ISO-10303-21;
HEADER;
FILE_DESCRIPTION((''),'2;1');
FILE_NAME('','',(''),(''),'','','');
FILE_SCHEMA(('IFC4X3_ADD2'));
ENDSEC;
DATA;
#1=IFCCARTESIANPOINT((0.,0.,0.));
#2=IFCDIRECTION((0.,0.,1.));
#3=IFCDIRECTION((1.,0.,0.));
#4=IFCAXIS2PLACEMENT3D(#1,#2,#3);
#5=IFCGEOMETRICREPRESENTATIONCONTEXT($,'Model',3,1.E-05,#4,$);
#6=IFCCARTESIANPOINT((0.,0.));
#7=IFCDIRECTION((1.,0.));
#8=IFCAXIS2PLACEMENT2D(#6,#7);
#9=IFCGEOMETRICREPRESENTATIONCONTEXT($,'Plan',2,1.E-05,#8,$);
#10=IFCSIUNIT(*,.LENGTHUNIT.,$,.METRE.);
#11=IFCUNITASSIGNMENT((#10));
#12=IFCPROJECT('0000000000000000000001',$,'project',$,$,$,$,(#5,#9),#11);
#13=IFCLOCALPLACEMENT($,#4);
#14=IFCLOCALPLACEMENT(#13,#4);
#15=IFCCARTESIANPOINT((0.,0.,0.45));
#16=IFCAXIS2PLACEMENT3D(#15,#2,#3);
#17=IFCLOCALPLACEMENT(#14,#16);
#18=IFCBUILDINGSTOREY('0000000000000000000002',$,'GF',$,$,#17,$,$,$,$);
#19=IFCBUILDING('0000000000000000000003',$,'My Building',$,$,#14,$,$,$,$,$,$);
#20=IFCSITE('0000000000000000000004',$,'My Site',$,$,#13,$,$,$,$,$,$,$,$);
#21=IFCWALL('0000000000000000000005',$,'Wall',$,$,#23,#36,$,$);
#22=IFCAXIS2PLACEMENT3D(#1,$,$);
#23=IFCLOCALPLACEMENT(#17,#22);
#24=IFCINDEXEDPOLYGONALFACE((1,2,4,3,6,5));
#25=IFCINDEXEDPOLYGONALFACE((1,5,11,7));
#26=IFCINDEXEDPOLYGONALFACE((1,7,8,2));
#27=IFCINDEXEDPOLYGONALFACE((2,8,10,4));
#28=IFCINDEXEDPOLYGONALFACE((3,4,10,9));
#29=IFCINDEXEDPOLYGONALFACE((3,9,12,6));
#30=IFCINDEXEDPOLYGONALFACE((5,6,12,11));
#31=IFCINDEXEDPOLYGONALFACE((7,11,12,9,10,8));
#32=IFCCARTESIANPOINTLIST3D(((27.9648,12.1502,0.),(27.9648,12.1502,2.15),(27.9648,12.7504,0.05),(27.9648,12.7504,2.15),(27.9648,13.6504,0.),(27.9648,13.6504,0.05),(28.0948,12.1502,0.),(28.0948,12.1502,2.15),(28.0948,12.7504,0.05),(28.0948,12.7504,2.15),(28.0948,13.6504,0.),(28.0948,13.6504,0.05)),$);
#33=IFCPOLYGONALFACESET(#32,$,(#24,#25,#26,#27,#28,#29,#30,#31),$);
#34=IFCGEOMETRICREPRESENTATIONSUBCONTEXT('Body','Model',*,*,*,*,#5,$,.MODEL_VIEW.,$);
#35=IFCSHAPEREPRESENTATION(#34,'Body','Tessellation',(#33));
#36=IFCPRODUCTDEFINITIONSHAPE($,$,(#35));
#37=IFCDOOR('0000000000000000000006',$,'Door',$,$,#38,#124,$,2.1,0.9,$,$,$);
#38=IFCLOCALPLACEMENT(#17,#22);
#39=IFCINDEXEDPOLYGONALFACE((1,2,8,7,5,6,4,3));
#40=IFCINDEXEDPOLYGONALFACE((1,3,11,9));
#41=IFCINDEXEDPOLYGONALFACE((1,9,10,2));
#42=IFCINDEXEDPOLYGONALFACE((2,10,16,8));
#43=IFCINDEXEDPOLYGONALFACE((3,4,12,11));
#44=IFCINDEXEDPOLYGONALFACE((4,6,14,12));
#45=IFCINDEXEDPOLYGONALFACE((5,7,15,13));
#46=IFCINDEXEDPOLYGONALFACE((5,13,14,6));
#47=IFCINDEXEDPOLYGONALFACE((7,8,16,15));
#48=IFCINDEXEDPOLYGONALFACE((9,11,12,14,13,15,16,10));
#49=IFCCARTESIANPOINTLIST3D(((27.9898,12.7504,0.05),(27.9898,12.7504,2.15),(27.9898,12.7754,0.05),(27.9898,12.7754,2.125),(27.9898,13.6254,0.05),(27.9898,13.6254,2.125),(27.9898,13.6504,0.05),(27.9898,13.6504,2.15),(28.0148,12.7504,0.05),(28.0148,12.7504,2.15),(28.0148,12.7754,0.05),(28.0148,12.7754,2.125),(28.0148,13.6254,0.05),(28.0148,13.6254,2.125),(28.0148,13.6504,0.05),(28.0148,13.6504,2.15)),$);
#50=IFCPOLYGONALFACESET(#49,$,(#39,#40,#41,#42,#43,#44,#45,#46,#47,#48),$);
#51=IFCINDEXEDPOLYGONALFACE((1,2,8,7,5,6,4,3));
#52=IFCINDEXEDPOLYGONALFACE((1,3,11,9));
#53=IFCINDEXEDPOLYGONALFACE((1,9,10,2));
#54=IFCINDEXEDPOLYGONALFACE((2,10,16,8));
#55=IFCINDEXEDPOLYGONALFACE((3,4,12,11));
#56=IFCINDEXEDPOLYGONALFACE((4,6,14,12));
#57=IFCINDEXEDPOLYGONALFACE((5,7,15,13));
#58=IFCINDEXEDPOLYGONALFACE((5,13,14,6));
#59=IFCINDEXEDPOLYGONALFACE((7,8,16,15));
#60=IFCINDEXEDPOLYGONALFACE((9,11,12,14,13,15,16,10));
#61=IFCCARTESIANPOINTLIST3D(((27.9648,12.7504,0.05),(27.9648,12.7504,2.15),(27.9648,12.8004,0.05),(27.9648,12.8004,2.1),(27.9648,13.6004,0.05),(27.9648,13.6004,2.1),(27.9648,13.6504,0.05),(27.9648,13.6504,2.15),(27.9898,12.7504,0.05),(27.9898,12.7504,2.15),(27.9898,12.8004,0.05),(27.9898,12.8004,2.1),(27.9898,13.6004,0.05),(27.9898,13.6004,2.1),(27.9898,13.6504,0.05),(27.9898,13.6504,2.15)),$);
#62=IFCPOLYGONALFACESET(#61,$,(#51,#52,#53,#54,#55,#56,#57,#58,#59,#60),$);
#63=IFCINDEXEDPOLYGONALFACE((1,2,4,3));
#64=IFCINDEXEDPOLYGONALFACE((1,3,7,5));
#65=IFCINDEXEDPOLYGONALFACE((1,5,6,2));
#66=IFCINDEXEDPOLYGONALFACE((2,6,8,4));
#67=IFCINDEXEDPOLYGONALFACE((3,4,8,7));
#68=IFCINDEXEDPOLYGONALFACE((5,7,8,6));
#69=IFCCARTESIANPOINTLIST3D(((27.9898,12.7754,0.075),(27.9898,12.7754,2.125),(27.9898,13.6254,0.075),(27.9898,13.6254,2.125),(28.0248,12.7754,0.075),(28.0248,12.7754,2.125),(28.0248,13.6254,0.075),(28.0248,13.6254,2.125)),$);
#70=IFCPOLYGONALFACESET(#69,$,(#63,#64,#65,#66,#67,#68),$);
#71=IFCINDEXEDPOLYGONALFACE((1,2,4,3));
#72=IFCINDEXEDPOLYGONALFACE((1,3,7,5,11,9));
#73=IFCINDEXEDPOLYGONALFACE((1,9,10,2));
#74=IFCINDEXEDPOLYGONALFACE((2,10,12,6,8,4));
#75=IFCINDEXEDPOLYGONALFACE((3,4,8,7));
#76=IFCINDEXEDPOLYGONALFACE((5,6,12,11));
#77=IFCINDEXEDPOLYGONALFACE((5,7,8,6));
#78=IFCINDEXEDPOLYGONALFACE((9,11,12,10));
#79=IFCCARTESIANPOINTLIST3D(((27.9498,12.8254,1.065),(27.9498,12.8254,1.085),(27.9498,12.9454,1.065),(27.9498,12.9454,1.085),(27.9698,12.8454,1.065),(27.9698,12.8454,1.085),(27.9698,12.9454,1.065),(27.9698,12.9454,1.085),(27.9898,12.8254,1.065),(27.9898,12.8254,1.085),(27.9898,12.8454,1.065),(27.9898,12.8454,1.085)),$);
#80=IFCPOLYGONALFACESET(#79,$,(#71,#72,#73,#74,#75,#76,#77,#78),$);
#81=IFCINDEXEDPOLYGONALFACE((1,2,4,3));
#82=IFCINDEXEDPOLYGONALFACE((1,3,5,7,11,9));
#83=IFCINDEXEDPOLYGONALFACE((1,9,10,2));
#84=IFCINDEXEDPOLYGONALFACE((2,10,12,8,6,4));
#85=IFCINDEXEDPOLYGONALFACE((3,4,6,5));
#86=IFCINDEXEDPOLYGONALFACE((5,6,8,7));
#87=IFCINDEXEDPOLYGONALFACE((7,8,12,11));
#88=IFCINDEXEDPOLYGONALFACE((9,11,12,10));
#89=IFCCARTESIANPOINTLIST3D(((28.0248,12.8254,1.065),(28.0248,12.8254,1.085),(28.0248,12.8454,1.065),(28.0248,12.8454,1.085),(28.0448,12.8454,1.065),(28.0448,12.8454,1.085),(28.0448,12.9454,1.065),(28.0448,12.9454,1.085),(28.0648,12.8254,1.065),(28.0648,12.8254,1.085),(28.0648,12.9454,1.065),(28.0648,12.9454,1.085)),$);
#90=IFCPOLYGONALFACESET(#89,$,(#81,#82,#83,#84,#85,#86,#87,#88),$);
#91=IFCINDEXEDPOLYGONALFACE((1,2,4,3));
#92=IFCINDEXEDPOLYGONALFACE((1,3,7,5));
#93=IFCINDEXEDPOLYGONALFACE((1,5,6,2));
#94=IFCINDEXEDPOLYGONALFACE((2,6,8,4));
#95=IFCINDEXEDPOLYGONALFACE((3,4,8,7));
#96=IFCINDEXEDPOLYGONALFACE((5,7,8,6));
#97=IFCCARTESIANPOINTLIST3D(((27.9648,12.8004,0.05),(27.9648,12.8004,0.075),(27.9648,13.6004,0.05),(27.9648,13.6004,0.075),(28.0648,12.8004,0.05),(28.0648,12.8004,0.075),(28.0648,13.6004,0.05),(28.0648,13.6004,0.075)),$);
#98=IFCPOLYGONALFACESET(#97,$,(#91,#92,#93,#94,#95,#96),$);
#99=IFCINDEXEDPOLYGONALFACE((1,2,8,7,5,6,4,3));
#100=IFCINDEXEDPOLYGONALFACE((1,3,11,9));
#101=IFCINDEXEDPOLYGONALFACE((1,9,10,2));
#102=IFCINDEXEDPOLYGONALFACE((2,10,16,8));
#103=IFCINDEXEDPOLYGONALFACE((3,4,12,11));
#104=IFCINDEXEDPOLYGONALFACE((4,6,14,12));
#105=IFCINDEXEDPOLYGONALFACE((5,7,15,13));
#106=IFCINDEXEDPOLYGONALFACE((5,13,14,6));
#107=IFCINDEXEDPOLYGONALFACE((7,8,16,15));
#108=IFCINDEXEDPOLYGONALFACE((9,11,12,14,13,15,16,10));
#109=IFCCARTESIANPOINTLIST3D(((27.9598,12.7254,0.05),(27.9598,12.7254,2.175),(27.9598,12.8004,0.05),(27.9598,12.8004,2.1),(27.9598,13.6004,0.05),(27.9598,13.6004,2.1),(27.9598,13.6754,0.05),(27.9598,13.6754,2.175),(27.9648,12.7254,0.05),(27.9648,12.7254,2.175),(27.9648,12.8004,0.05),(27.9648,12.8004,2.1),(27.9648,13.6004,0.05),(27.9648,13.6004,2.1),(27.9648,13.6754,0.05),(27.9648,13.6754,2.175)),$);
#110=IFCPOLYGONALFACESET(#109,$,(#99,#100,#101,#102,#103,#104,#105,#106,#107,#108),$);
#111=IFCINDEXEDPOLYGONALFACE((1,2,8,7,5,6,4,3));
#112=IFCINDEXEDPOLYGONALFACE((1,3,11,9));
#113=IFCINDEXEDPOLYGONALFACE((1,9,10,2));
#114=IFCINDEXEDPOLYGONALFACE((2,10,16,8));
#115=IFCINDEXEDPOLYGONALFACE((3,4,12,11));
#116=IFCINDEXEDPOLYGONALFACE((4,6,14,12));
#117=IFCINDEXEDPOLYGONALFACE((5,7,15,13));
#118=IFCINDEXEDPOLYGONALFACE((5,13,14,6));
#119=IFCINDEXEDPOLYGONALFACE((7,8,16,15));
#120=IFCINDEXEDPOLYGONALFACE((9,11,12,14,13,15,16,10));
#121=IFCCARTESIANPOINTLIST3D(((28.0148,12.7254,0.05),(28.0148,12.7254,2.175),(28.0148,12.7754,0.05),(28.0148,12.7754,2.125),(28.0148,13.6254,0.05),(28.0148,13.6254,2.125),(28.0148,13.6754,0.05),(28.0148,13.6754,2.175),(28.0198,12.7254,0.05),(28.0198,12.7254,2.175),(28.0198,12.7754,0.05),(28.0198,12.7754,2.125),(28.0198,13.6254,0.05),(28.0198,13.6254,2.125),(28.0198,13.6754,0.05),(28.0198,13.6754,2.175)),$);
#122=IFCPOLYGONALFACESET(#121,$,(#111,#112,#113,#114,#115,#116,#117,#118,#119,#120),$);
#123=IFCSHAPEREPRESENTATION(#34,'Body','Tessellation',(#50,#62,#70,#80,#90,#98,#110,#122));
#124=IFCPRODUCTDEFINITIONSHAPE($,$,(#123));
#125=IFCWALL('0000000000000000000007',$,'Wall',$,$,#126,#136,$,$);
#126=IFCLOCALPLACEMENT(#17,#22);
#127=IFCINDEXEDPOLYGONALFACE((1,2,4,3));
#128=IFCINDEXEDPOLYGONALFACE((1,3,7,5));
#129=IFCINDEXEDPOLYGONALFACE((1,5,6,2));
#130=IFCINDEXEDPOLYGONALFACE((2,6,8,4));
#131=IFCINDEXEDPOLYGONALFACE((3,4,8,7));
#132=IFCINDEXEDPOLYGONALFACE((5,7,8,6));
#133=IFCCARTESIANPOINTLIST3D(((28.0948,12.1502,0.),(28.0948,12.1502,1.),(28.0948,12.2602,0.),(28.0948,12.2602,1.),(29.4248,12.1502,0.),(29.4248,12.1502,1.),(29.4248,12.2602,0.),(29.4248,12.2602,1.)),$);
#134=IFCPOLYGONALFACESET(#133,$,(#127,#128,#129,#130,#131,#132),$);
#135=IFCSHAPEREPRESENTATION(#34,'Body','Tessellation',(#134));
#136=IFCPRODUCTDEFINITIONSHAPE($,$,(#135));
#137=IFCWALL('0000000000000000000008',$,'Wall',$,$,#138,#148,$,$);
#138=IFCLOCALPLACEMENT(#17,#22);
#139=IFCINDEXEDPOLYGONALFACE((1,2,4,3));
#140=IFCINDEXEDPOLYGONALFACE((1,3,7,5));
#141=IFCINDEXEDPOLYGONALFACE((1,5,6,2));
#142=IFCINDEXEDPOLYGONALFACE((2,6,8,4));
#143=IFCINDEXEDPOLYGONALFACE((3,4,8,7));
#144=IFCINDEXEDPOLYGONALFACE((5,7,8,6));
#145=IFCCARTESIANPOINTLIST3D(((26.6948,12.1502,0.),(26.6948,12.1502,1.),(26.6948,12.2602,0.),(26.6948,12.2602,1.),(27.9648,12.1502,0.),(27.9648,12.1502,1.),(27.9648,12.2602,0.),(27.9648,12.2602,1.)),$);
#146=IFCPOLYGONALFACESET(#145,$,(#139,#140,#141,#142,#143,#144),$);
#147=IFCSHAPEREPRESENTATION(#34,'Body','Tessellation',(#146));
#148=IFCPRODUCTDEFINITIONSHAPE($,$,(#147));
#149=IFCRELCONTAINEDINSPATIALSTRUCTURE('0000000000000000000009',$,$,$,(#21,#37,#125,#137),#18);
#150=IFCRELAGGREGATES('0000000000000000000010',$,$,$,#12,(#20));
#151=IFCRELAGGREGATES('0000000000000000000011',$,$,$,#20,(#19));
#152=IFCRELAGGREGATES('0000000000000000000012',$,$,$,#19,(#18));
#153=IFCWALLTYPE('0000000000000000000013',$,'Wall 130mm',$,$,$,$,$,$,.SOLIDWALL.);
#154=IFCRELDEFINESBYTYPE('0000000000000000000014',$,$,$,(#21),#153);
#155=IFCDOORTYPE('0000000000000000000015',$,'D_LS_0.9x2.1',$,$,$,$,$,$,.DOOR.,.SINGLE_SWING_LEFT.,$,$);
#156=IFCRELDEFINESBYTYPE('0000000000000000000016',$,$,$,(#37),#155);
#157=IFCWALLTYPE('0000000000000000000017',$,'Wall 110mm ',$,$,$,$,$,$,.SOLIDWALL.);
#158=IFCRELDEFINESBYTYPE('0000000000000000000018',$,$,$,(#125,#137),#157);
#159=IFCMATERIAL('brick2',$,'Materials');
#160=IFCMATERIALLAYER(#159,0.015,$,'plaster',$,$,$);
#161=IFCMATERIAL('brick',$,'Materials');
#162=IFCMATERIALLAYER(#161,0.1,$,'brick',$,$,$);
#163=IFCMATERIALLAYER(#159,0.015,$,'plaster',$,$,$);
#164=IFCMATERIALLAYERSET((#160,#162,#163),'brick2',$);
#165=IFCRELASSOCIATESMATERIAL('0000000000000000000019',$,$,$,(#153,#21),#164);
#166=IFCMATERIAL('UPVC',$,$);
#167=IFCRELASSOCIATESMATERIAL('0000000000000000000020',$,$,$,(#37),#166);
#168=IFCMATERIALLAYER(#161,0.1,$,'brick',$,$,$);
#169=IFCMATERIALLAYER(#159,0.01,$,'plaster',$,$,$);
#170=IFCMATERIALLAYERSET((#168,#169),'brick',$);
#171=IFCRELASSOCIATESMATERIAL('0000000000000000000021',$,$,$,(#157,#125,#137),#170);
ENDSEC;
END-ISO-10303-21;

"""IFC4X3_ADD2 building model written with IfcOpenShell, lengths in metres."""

from ifc_helpers import new_model, entity, si_unit, frame, origin_with_axes, origin_2d_with_axis, place, context, subcontext, project, spatial, line, indexed_curve, outline, extrude, shape, source, transform, mapped, material, layer, layer_set, layer_usage, type_object, type_shapes, element, fill, save


model = new_model("IFC4X3_ADD2")

# Units and contexts
model_context = context("Model", 3, precision=1e-05, world=origin_with_axes())
plan_context = context("Plan", 2, precision=1e-05, world=origin_2d_with_axis())
body_context_1 = subcontext(model_context, "Body", "Model", "MODEL_VIEW")
body_context_2 = subcontext(plan_context, "Body", "Plan", "PLAN_VIEW")
ifc_project = project(units=[si_unit("LENGTHUNIT", "METRE")], contexts=[model_context, plan_context])

# Site, building, storey
site_placement = place(None, origin_with_axes())
site = spatial("IfcSite", under=ifc_project, at=site_placement, Name="My Site")
building_placement = place(site_placement, origin_with_axes())
building = spatial("IfcBuilding", under=site, at=building_placement, Name="My Building")
storey_placement = place(building_placement, frame((0.0, 0.0, 0.45), z_axis=(0.0, 0.0, 1.0), x_axis=(1.0, 0.0, 0.0)))
storey = spatial("IfcBuildingStorey", under=building, at=storey_placement, Name="GF")

# Shared definitions
ifc_material_1 = material(Name="UPVC")

# Shared definitions
ifc_material_2 = material(Name="brick2", Category="Materials")
ifc_material_3 = material(Name="brick", Category="Materials")

# Wall, opening, door
ifc_layer_1 = layer(ifc_material_2, 0.015, Name="plaster")
ifc_layer_2 = layer(ifc_material_3, 0.1, Name="brick")
ifc_layer_3 = layer(ifc_material_2, 0.015, Name="plaster")
ifc_layer_set_1 = layer_set([ifc_layer_1, ifc_layer_2, ifc_layer_3], Name="brick2")
ifc_layer_usage_1 = layer_usage(ifc_layer_set_1, "AXIS2", "POSITIVE", 0.0)
wall_type_1 = type_object("IfcWallType", Name="Wall 130mm", PredefinedType="SOLIDWALL", material=ifc_layer_set_1)
wall_1_placement = place(storey_placement, frame((27.9648, 13.9004, 0.0), z_axis=(0.0, 0.0, 1.0), x_axis=(0.0, -1.0, 0.0)))
wall_1 = element("IfcWall", 1, at=wall_1_placement, inside=storey, type_object=wall_type_1, material=ifc_layer_usage_1, Name="Wall", context=body_context_1, shape_type="SweptSolid", body=[
    extrude(outline(indexed_curve([(0.25, 0.0), (0.25, 0.13), (1.7502, 0.13), (1.7502, 0.0)], segments=[line(1, 2, 3, 4, 1)])), origin_with_axes(), (0.0, 0.0, 1.0), 2.15),
])
shared_shape_1 = source(origin_with_axes(), body_context_1, "Body", "SweptSolid", [
    extrude(outline(indexed_curve([(0.0, 0.0), (0.9, 0.0), (0.9, 2.1), (0.0, 2.1)], segments=[line(1, 2, 3, 4, 1)])), frame((0.0, -0.6, 0.0), z_axis=(0.0, -1.0, 0.0), x_axis=(1.0, 0.0, 0.0)), (0.0, 0.0, -1.0), 1.2),
])
opening_1_placement = place(wall_1_placement, frame((0.25, 0.0, 0.05), z_axis=(0.0, 0.0, 1.0), x_axis=(1.0, 0.0, 0.0)))
opening_1 = element("IfcOpeningElement", 2, at=opening_1_placement, cuts=wall_1, PredefinedType="OPENING", context=body_context_1, shape_type="MappedRepresentation", body=[
    mapped(shared_shape_1, transform((0.0, 0.0, 0.0), x_axis=(1.0, 0.0, 0.0), y_axis=(0.0, 1.0, 0.0), z_axis=(0.0, 0.0, 1.0), scale=1.0)),
])
door_type_1 = type_object("IfcDoorType", Name="D_LS_0.9x2.1", OperationType="SINGLE_SWING_LEFT", PredefinedType="DOOR")
shared_shape_2 = source(origin_with_axes(), body_context_1, "Body", "SweptSolid", [
    extrude(outline(indexed_curve([(0.0, 0.0), (0.0, 2.1), (0.9, 2.1), (0.9, 0.0), (0.875, 0.0), (0.875, 2.075), (0.025, 2.075), (0.025, 0.0)], segments=[line(1, 2, 3, 4, 5, 6, 7, 8, 1)])), frame((0.0, 0.025, 0.0), z_axis=(0.0, -1.0, 0.0), x_axis=(1.0, 0.0, 0.0)), (0.0, 0.0, -1.0), 0.025),
    extrude(outline(indexed_curve([(0.0, 0.0), (0.0, 2.1), (0.9, 2.1), (0.9, 0.0), (0.85, 0.0), (0.85, 2.05), (0.05, 2.05), (0.05, 0.0)], segments=[line(1, 2, 3, 4, 5, 6, 7, 8, 1)])), frame((0.0, 0.0, 0.0), z_axis=(0.0, -1.0, 0.0), x_axis=(1.0, 0.0, 0.0)), (0.0, 0.0, -1.0), 0.025),
    extrude(outline(indexed_curve([(0.0, 0.0), (0.85, 0.0), (0.85, 0.035), (0.0, 0.035)], segments=[line(1, 2, 3, 4, 1)])), frame((0.025, 0.025, 0.025), z_axis=(0.0, 0.0, 1.0), x_axis=(1.0, 0.0, 0.0)), (0.0, 0.0, 1.0), 2.05),
    extrude(outline(indexed_curve([(0.0, 0.0), (0.0, -0.04), (-0.12, -0.04), (-0.12, -0.02), (-0.02, -0.02), (-0.02, 0.0)], segments=[line(1, 2, 3, 4, 5, 6, 1)])), frame((0.825, 0.025, 1.015), z_axis=(0.0, 0.0, 1.0), x_axis=(1.0, 0.0, 0.0)), (0.0, 0.0, 1.0), 0.02),
    extrude(outline(indexed_curve([(0.0, 0.0), (0.0, 0.04), (-0.12, 0.04), (-0.12, 0.02), (-0.02, 0.02), (-0.02, 0.0)], segments=[line(1, 2, 3, 4, 5, 6, 1)])), frame((0.825, 0.06, 1.015), z_axis=(0.0, 0.0, 1.0), x_axis=(1.0, 0.0, 0.0)), (0.0, 0.0, 1.0), 0.02),
    extrude(outline(indexed_curve([(0.0, 0.0), (0.8, 0.0), (0.8, 0.1), (0.0, 0.1)], segments=[line(1, 2, 3, 4, 1)])), frame((0.05, 0.0, 0.0), z_axis=(0.0, 0.0, 1.0), x_axis=(1.0, 0.0, 0.0)), (0.0, 0.0, 1.0), 0.025),
    extrude(outline(indexed_curve([(0.0, 0.0), (0.0, 2.125), (0.95, 2.125), (0.95, 0.0), (0.875, 0.0), (0.875, 2.05), (0.075, 2.05), (0.075, 0.0)], segments=[line(1, 2, 3, 4, 5, 6, 7, 8, 1)])), frame((-0.025, -0.005, 0.0), z_axis=(0.0, -1.0, 0.0), x_axis=(1.0, 0.0, 0.0)), (0.0, 0.0, -1.0), 0.005),
    extrude(outline(indexed_curve([(0.0, 0.0), (0.0, 2.125), (0.95, 2.125), (0.95, 0.0), (0.9, 0.0), (0.9, 2.075), (0.05, 2.075), (0.05, 0.0)], segments=[line(1, 2, 3, 4, 5, 6, 7, 8, 1)])), frame((-0.025, 0.05, 0.0), z_axis=(0.0, -1.0, 0.0), x_axis=(1.0, 0.0, 0.0)), (0.0, 0.0, -1.0), 0.005),
])
shared_shape_3 = source(origin_with_axes(), body_context_2, "Body", "Curve2D", [
    entity("IfcIndexedPolyCurve", entity("IfcCartesianPointList2D", [[0.0, 0.0], [0.0, 0.05], [0.025, 0.05], [0.025, 0.025], [0.05, 0.025], [0.05, 0.0]]), [entity("IfcLineIndex", [1, 2, 3, 4, 5, 6, 1])]),
    entity("IfcIndexedPolyCurve", entity("IfcCartesianPointList2D", [[0.9, 0.0], [0.9, 0.05], [0.875, 0.05], [0.875, 0.025], [0.85, 0.025], [0.85, 0.0]]), [entity("IfcLineIndex", [1, 2, 3, 4, 5, 6, 1])]),
    entity("IfcTrimmedCurve", entity("IfcEllipse", entity("IfcAxis2Placement2D", entity("IfcCartesianPoint", [0.06, 0.05]), entity("IfcDirection", [1.0, 0.0])), 0.815, 0.85), [entity("IfcCartesianPoint", [0.875, 0.05])], [entity("IfcCartesianPoint", [0.06, 0.9])], True, "CARTESIAN"),
    entity("IfcIndexedPolyCurve", entity("IfcCartesianPointList2D", [[0.025, 0.05], [0.06, 0.05], [0.06, 0.9], [0.025, 0.9]]), [entity("IfcLineIndex", [1, 2, 3, 4, 1])]),
])
type_shapes(door_type_1, [shared_shape_2, shared_shape_3])
door_1_placement = place(opening_1_placement, origin_with_axes())
door_1 = element("IfcDoor", 3, at=door_1_placement, inside=storey, type_object=door_type_1, material=ifc_material_1, Name="Door", OverallHeight=2.1, OverallWidth=0.9, shapes=[
    shape(body_context_1, "Body", "MappedRepresentation", [mapped(shared_shape_2, transform((0.0, 0.0, 0.0), x_axis=(1.0, 0.0, 0.0), y_axis=(0.0, 1.0, 0.0), z_axis=(0.0, 0.0, 1.0), scale=1.0))]),
    shape(body_context_2, "Body", "MappedRepresentation", [mapped(shared_shape_3, transform((0.0, 0.0, 0.0), x_axis=(1.0, 0.0, 0.0), y_axis=(0.0, 1.0, 0.0), z_axis=(0.0, 0.0, 1.0), scale=1.0))]),
])
fill(opening_1, door_1)

# Walls
ifc_layer_4 = layer(ifc_material_3, 0.1, Name="brick")
ifc_layer_5 = layer(ifc_material_2, 0.01, Name="plaster")
ifc_layer_set_2 = layer_set([ifc_layer_4, ifc_layer_5], Name="brick")
ifc_layer_usage_2 = layer_usage(ifc_layer_set_2, "AXIS2", "NEGATIVE", 0.0)
wall_type_2 = type_object("IfcWallType", Name="Wall 110mm ", PredefinedType="SOLIDWALL", material=ifc_layer_set_2)
wall_2_placement = place(storey_placement, frame((29.4248, 12.1502, 0.0), z_axis=(0.0, 0.0, 1.0), x_axis=(-1.0, 0.0, 0.0)))
element("IfcWall", 4, at=wall_2_placement, inside=storey, type_object=wall_type_2, material=ifc_layer_usage_2, Name="Wall", context=body_context_1, shape_type="SweptSolid", body=[
    extrude(outline(indexed_curve([(0.0, -0.11), (0.0, 0.0), (1.33, 0.0), (1.33, -0.11)], segments=[line(1, 2, 3, 4, 1)])), origin_with_axes(), (0.0, 0.0, 1.0), 1.0),
])
ifc_layer_usage_3 = layer_usage(ifc_layer_set_2, "AXIS2", "NEGATIVE", 0.0)
wall_3_placement = place(storey_placement, frame((27.9648, 12.1502, 0.0), z_axis=(0.0, 0.0, 1.0), x_axis=(-1.0, 0.0, 0.0)))
element("IfcWall", 5, at=wall_3_placement, inside=storey, type_object=wall_type_2, material=ifc_layer_usage_3, Name="Wall", context=body_context_1, shape_type="SweptSolid", body=[
    extrude(outline(indexed_curve([(0.0, -0.11), (0.0, 0.0), (1.27, 0.0), (1.27, -0.11)], segments=[line(1, 2, 3, 4, 1)])), origin_with_axes(), (0.0, 0.0, 1.0), 1.0),
])

save(model, "model.ifc")
